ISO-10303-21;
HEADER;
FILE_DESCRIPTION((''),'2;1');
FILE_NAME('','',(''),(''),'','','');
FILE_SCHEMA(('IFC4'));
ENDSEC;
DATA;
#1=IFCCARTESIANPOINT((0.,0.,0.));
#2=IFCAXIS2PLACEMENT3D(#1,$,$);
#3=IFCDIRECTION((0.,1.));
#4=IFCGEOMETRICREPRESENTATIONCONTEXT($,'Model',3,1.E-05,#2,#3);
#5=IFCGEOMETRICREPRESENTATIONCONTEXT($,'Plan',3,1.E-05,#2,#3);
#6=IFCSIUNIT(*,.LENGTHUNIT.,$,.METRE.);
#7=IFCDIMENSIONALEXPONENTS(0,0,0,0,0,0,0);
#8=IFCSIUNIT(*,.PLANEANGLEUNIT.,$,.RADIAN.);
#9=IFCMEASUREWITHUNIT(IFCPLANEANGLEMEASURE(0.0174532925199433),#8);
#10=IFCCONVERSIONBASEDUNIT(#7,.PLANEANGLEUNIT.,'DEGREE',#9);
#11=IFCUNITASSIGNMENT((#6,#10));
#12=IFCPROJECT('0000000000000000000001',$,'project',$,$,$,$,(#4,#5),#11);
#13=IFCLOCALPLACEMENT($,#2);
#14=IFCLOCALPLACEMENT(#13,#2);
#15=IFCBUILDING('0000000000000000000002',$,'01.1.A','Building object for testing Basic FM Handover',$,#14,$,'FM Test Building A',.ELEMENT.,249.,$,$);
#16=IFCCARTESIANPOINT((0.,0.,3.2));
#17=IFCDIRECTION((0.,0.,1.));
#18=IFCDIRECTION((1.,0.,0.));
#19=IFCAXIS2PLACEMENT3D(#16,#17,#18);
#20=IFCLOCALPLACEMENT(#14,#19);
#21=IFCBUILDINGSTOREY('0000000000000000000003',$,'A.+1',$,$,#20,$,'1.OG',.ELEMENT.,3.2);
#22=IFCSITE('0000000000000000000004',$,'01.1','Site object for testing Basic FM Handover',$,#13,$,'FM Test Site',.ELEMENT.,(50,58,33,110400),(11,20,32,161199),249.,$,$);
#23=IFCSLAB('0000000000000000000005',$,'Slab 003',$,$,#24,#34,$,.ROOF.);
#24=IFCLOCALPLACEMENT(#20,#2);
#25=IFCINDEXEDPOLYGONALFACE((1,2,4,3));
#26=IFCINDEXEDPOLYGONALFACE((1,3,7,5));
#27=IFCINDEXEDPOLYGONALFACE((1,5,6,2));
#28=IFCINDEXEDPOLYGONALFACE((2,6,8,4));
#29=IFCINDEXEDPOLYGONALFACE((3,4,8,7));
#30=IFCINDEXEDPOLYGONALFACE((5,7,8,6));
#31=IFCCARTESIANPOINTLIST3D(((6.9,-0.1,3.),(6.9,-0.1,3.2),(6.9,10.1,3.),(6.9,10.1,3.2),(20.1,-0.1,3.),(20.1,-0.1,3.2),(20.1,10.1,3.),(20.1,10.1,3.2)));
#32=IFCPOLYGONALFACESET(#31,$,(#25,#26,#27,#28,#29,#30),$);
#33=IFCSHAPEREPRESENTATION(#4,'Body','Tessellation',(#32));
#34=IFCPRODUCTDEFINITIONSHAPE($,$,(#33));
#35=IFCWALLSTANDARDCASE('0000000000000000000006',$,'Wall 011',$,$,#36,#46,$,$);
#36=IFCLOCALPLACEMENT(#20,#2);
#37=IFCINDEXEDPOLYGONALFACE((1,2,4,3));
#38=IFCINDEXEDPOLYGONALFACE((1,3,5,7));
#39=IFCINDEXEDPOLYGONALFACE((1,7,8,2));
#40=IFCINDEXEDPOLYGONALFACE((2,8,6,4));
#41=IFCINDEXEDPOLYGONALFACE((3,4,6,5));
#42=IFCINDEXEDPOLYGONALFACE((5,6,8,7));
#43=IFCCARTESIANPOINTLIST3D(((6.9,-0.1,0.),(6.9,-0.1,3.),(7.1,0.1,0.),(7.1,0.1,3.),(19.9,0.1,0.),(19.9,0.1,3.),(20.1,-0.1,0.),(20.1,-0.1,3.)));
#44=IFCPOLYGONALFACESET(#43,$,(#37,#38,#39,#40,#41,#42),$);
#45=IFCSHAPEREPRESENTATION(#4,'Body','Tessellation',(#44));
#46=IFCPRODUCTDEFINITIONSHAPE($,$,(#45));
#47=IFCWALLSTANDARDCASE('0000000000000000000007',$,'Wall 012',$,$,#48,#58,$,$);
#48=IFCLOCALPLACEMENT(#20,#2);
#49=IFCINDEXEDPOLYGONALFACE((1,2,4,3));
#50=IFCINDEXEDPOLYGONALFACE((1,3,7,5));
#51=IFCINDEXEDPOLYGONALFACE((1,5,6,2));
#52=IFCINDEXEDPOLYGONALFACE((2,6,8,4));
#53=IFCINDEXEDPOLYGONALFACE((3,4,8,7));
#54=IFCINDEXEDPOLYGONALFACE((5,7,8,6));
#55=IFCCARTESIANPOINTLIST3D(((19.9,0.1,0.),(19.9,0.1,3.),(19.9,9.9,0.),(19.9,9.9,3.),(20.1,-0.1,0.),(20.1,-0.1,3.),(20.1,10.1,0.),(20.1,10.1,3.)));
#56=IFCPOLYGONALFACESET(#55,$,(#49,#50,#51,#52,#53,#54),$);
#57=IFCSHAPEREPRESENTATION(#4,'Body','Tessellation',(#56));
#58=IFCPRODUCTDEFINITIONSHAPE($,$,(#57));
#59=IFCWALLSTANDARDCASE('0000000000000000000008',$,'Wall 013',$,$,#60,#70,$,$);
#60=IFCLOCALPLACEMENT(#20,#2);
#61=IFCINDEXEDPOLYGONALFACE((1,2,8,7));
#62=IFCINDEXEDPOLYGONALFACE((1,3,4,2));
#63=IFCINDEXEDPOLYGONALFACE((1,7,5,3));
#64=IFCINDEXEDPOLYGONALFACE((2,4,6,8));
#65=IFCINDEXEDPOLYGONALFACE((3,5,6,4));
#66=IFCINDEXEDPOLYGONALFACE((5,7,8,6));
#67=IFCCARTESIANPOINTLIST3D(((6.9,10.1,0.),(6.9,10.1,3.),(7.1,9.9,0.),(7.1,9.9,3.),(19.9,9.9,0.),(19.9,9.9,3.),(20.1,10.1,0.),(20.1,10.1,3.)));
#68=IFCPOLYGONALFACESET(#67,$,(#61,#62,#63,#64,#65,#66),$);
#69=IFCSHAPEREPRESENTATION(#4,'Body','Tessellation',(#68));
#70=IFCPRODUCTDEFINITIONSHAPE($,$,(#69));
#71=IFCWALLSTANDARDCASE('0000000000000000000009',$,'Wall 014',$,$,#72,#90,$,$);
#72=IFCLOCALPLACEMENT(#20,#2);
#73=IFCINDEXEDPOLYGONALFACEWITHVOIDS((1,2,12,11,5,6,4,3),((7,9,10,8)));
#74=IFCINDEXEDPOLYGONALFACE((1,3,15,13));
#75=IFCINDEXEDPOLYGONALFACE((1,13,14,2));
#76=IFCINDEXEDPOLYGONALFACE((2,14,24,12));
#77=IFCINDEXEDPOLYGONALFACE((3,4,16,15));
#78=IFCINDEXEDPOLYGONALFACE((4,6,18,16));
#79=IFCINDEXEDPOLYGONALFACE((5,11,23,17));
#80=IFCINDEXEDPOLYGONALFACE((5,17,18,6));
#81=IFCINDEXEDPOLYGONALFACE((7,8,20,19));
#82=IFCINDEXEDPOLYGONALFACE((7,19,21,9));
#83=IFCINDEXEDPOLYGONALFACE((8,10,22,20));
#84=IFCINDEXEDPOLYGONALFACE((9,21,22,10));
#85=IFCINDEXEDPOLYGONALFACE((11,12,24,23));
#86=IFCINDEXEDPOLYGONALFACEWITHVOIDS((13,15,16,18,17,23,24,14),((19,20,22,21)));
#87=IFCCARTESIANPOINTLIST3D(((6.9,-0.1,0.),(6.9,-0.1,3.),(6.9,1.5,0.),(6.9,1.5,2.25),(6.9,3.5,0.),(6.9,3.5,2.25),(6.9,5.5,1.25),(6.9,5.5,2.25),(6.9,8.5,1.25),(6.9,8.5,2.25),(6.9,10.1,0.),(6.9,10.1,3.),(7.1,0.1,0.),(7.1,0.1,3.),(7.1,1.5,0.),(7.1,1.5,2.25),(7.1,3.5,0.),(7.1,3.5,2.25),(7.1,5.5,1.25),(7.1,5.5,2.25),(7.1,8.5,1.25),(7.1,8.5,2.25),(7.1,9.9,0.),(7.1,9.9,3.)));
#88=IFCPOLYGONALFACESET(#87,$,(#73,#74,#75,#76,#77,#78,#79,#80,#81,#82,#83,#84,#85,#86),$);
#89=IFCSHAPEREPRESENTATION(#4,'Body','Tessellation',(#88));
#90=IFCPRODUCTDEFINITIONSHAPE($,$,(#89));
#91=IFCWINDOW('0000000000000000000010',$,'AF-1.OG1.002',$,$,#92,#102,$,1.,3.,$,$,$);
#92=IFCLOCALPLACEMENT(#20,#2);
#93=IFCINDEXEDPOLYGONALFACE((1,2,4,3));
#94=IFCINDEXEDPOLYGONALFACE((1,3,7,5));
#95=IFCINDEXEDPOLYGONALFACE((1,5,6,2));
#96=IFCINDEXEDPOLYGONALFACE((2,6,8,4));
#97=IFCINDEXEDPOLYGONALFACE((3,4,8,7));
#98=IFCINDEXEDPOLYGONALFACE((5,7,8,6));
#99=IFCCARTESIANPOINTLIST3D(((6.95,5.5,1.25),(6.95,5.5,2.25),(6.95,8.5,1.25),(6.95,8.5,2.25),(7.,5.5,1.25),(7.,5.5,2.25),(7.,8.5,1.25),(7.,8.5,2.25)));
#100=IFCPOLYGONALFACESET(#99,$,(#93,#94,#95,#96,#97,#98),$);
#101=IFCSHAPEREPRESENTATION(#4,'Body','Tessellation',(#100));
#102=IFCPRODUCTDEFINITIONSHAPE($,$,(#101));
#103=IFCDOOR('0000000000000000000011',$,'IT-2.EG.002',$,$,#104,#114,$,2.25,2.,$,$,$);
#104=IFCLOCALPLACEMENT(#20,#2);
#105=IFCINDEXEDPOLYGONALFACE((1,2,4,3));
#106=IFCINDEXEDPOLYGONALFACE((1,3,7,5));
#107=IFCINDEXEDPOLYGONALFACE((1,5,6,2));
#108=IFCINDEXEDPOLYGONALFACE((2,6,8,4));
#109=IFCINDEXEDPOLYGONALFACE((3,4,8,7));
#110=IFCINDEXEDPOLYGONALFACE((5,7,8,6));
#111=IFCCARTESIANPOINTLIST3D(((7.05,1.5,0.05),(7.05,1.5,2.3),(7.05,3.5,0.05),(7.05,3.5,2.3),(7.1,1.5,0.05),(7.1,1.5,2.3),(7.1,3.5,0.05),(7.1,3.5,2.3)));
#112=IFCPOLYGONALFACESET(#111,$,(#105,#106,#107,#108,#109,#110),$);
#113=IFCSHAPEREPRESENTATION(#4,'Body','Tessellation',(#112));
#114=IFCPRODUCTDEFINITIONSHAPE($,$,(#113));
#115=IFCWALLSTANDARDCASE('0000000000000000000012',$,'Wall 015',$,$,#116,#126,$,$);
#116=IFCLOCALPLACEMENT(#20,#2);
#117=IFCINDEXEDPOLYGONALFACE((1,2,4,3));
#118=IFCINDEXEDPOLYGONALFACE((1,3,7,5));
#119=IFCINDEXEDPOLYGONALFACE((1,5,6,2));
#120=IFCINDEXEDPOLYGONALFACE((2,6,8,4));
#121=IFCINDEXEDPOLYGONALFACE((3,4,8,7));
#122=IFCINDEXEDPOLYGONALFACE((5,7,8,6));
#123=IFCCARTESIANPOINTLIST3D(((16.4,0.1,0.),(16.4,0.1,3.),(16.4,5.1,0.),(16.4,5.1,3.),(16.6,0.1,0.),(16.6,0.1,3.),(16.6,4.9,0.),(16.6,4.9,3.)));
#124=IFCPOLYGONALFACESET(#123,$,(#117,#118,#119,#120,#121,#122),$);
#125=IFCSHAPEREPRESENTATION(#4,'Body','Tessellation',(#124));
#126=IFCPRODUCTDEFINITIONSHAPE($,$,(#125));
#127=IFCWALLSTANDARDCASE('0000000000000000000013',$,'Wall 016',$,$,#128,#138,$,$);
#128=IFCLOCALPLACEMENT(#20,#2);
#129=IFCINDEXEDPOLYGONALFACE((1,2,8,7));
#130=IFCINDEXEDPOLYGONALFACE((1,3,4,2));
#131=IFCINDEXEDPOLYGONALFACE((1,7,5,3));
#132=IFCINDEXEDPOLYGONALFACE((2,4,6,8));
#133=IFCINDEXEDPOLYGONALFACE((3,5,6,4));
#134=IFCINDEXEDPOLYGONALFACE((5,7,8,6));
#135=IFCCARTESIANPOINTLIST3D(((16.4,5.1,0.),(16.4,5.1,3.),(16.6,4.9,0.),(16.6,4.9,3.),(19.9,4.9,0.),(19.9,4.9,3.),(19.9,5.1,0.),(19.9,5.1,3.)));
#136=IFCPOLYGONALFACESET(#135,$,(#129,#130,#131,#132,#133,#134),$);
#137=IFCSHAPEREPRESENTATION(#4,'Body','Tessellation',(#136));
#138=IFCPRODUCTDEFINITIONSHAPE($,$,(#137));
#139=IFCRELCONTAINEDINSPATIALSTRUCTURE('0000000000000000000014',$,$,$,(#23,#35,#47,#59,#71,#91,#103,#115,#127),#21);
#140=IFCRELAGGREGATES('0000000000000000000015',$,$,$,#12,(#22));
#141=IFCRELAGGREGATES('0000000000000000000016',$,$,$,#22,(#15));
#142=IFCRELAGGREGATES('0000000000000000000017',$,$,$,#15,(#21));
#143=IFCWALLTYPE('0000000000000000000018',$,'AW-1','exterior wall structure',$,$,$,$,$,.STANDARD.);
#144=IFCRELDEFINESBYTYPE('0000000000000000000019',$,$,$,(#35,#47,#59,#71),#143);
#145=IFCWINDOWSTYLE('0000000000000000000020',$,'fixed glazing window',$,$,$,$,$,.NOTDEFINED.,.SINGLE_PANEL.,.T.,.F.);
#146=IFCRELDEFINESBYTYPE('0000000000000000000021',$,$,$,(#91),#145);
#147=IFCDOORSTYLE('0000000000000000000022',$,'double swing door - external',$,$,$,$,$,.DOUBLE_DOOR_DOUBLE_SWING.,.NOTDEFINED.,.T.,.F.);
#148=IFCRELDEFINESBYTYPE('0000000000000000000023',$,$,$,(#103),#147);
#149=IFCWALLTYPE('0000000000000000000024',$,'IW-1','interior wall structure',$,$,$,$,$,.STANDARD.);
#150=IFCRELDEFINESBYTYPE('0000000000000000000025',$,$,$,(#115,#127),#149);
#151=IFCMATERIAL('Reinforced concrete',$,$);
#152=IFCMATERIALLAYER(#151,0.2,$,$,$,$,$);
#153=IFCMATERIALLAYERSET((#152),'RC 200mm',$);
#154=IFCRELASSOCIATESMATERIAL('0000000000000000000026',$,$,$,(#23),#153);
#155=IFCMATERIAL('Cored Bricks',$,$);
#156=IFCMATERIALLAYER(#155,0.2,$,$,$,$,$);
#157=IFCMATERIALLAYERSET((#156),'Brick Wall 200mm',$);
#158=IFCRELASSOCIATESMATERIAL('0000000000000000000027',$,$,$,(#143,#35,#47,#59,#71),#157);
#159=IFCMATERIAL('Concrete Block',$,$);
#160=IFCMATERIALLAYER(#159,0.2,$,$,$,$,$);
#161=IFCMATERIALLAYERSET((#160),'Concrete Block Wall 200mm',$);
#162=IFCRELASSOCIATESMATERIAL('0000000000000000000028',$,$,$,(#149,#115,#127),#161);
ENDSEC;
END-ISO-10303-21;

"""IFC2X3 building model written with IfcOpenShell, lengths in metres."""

from ifc_helpers import new_model, entity, si_unit, converted_unit, direction, frame, frame_2d, origin, origin_with_axes, place, context, project, spatial, polyline, rectangle, outline, extrude, material, layer, layer_set, layer_usage, type_object, element, fill, save


model = new_model("IFC2X3")

# Units and contexts
model_context = context("Model", 3, precision=1e-05, world=origin(), true_north=direction((0.0, 1.0)))
plan_context = context("Plan", 3, precision=1e-05, world=origin(), true_north=direction((0.0, 1.0)))
ifc_project = project(units=[si_unit("LENGTHUNIT", "METRE"), converted_unit("PLANEANGLEUNIT", "DEGREE", entity("IfcPlaneAngleMeasure", 0.0174532925199433), si_unit("PLANEANGLEUNIT", "RADIAN"), dimensions=[0, 0, 0, 0, 0, 0, 0])], contexts=[model_context, plan_context])

# Site, building, storey
site_placement = place(None, origin())
site = spatial("IfcSite", under=ifc_project, at=site_placement, Name="01.1", Description="Site object for testing Basic FM Handover", LongName="FM Test Site", CompositionType="ELEMENT", RefLatitude=(50, 58, 33, 110400), RefLongitude=(11, 20, 32, 161199), RefElevation=249.0)
building_placement = place(site_placement, origin())
building = spatial("IfcBuilding", under=site, at=building_placement, Name="01.1.A", Description="Building object for testing Basic FM Handover", LongName="FM Test Building A", CompositionType="ELEMENT", ElevationOfRefHeight=249.0)
storey_placement = place(building_placement, frame((0.0, 0.0, 3.2), z_axis=(0.0, 0.0, 1.0), x_axis=(1.0, 0.0, 0.0)))
storey = spatial("IfcBuildingStorey", under=building, at=storey_placement, Name="A.+1", LongName="1.OG", CompositionType="ELEMENT", Elevation=3.2)

# Slab
ifc_material_1 = material(Name="Reinforced concrete")
ifc_layer_1 = layer(ifc_material_1, 0.2)
ifc_layer_set_1 = layer_set([ifc_layer_1], Name="RC 200mm")
ifc_layer_usage_1 = layer_usage(ifc_layer_set_1, "AXIS3", "POSITIVE", 0.0)
slab_placement = place(storey_placement, frame((7.0, 0.0, 3.0), z_axis=(0.0, 0.0, 1.0), x_axis=(1.0, 0.0, 0.0)))
element("IfcSlab", 1, at=slab_placement, inside=storey, material=ifc_layer_usage_1, Name="Slab 003", PredefinedType="ROOF", context=model_context, shape_type="SweptSolid", body=[
    extrude(outline(polyline([(-0.1, -0.1), (13.1, -0.1), (13.1, 10.1), (-0.1, 10.1), (-0.1, -0.1)])), origin(), (0.0, 0.0, 1.0), 0.2),
])

# Walls
ifc_material_2 = material(Name="Cored Bricks")
ifc_layer_2 = layer(ifc_material_2, 0.2)
ifc_layer_set_2 = layer_set([ifc_layer_2], Name="Brick Wall 200mm")
ifc_layer_usage_2 = layer_usage(ifc_layer_set_2, "AXIS2", "POSITIVE", -0.1)
wall_type_1 = type_object("IfcWallType", Name="AW-1", Description="exterior wall structure", PredefinedType="STANDARD", material=ifc_layer_set_2)
wall_1_placement = place(storey_placement, frame((7.0, 0.0, 0.0), z_axis=(0.0, 0.0, 1.0), x_axis=(1.0, 0.0, 0.0)))
element("IfcWallStandardCase", 2, at=wall_1_placement, inside=storey, type_object=wall_type_1, material=ifc_layer_usage_2, Name="Wall 011", context=model_context, shape_type="SweptSolid", body=[
    extrude(outline(polyline([(-0.1, -0.1), (13.1, -0.1), (12.9, 0.1), (0.1, 0.1), (-0.1, -0.1)])), origin(), (0.0, 0.0, 1.0), 3.0),
])
ifc_layer_usage_3 = layer_usage(ifc_layer_set_2, "AXIS2", "POSITIVE", -0.1)
wall_2_placement = place(storey_placement, frame((20.0, 0.0, 0.0), z_axis=(0.0, 0.0, 1.0), x_axis=(0.0, 1.0, 0.0)))
element("IfcWallStandardCase", 3, at=wall_2_placement, inside=storey, type_object=wall_type_1, material=ifc_layer_usage_3, Name="Wall 012", context=model_context, shape_type="SweptSolid", body=[
    extrude(outline(polyline([(-0.1, -0.1), (10.1, -0.1), (9.9, 0.1), (0.1, 0.1), (-0.1, -0.1)])), origin(), (0.0, 0.0, 1.0), 3.0),
])
ifc_layer_usage_4 = layer_usage(ifc_layer_set_2, "AXIS2", "POSITIVE", -0.1)
wall_3_placement = place(storey_placement, frame((20.0, 10.0, 0.0), z_axis=(0.0, 0.0, 1.0), x_axis=(-1.0, 0.0, 0.0)))
element("IfcWallStandardCase", 4, at=wall_3_placement, inside=storey, type_object=wall_type_1, material=ifc_layer_usage_4, Name="Wall 013", context=model_context, shape_type="SweptSolid", body=[
    extrude(outline(polyline([(-0.1, -0.1), (13.1, -0.1), (12.9, 0.1), (0.1, 0.1), (-0.1, -0.1)])), origin(), (0.0, 0.0, 1.0), 3.0),
])

# Wall, openings, window, door
ifc_layer_usage_5 = layer_usage(ifc_layer_set_2, "AXIS2", "POSITIVE", -0.1)
wall_4_placement = place(storey_placement, frame((7.0, 10.0, 0.0), z_axis=(0.0, 0.0, 1.0), x_axis=(0.0, -1.0, 0.0)))
wall_4 = element("IfcWallStandardCase", 5, at=wall_4_placement, inside=storey, type_object=wall_type_1, material=ifc_layer_usage_5, Name="Wall 014", context=model_context, shape_type="SweptSolid", body=[
    extrude(outline(polyline([(-0.1, -0.1), (10.1, -0.1), (9.9, 0.1), (0.1, 0.1), (-0.1, -0.1)])), origin(), (0.0, 0.0, 1.0), 3.0),
])
opening_1_placement = place(wall_4_placement, frame((6.5, -0.1, 0.0), z_axis=(0.0, 0.0, 1.0), x_axis=(1.0, 0.0, 0.0)))
opening_1 = element("IfcOpeningElement", 6, at=opening_1_placement, cuts=wall_4, context=model_context, shape_type="SweptSolid", body=[
    extrude(rectangle(XDim=2.25, YDim=2.0, at=frame_2d((1.125, 1.0))), frame((0.0, 0.0, 0.0), z_axis=(0.0, 1.0, 0.0), x_axis=(0.0, 0.0, 1.0)), (0.0, 0.0, 1.0), 0.2),
])
opening_2_placement = place(wall_4_placement, frame((1.5, -0.1, 1.25), z_axis=(0.0, 0.0, 1.0), x_axis=(1.0, 0.0, 0.0)))
opening_2 = element("IfcOpeningElement", 7, at=opening_2_placement, cuts=wall_4, context=model_context, shape_type="SweptSolid", body=[
    extrude(rectangle(XDim=1.0, YDim=3.0, at=frame_2d((0.5, 1.5))), frame((0.0, 0.0, 0.0), z_axis=(0.0, 1.0, 0.0), x_axis=(0.0, 0.0, 1.0)), (0.0, 0.0, 1.0), 0.2),
])
window_style = type_object("IfcWindowStyle", Name="fixed glazing window", ConstructionType="NOTDEFINED", OperationType="SINGLE_PANEL", ParameterTakesPrecedence=True, Sizeable=False)
window_placement = place(opening_2_placement, frame((0.0, 0.05, 0.0), z_axis=(0.0, 0.0, 1.0), x_axis=(1.0, 0.0, 0.0)))
window = element("IfcWindow", 8, at=window_placement, inside=storey, type_object=window_style, Name="AF-1.OG1.002", OverallHeight=1.0, OverallWidth=3.0, context=model_context, shape_type="SweptSolid", body=[
    extrude(rectangle(XDim=1.0, YDim=3.0, at=frame_2d((0.5, 1.5))), frame((0.0, 0.0, 0.0), z_axis=(0.0, 1.0, 0.0), x_axis=(0.0, 0.0, 1.0)), (0.0, 0.0, 1.0), 0.05),
])
fill(opening_2, window)
door_style = type_object("IfcDoorStyle", Name="double swing door - external", ConstructionType="NOTDEFINED", OperationType="DOUBLE_DOOR_DOUBLE_SWING", ParameterTakesPrecedence=True, Sizeable=False)
door_placement = place(opening_1_placement, origin_with_axes())
door = element("IfcDoor", 9, at=door_placement, inside=storey, type_object=door_style, Name="IT-2.EG.002", OverallHeight=2.25, OverallWidth=2.0, context=model_context, shape_type="SweptSolid", body=[
    extrude(rectangle(XDim=2.25, YDim=2.0, at=frame_2d((1.075, 1.0))), frame((0.0, 0.15, 0.1), z_axis=(0.0, 1.0, 0.0), x_axis=(0.0, 0.0, 1.0)), (0.0, 0.0, 1.0), 0.05),
])
fill(opening_1, door)

# Walls
ifc_material_3 = material(Name="Concrete Block")
ifc_layer_3 = layer(ifc_material_3, 0.2)
ifc_layer_set_3 = layer_set([ifc_layer_3], Name="Concrete Block Wall 200mm")
ifc_layer_usage_6 = layer_usage(ifc_layer_set_3, "AXIS2", "POSITIVE", -0.1)
wall_type_2 = type_object("IfcWallType", Name="IW-1", Description="interior wall structure", PredefinedType="STANDARD", material=ifc_layer_set_3)
wall_5_placement = place(storey_placement, frame((16.5, 0.0, 0.0), z_axis=(0.0, 0.0, 1.0), x_axis=(0.0, 1.0, 0.0)))
element("IfcWallStandardCase", 10, at=wall_5_placement, inside=storey, type_object=wall_type_2, material=ifc_layer_usage_6, Name="Wall 015", context=model_context, shape_type="SweptSolid", body=[
    extrude(outline(polyline([(0.1, -0.1), (4.9, -0.1), (5.1, 0.1), (0.1, 0.1), (0.1, -0.1)])), origin(), (0.0, 0.0, 1.0), 3.0),
])
ifc_layer_usage_7 = layer_usage(ifc_layer_set_3, "AXIS2", "POSITIVE", -0.1)
wall_6_placement = place(storey_placement, frame((16.5, 5.0, 0.0), z_axis=(0.0, 0.0, 1.0), x_axis=(1.0, 0.0, 0.0)))
element("IfcWallStandardCase", 11, at=wall_6_placement, inside=storey, type_object=wall_type_2, material=ifc_layer_usage_7, Name="Wall 016", context=model_context, shape_type="SweptSolid", body=[
    extrude(outline(polyline([(0.1, -0.1), (3.4, -0.1), (3.4, 0.1), (-0.1, 0.1), (0.1, -0.1)])), origin(), (0.0, 0.0, 1.0), 3.0),
])

save(model, "model.ifc")
